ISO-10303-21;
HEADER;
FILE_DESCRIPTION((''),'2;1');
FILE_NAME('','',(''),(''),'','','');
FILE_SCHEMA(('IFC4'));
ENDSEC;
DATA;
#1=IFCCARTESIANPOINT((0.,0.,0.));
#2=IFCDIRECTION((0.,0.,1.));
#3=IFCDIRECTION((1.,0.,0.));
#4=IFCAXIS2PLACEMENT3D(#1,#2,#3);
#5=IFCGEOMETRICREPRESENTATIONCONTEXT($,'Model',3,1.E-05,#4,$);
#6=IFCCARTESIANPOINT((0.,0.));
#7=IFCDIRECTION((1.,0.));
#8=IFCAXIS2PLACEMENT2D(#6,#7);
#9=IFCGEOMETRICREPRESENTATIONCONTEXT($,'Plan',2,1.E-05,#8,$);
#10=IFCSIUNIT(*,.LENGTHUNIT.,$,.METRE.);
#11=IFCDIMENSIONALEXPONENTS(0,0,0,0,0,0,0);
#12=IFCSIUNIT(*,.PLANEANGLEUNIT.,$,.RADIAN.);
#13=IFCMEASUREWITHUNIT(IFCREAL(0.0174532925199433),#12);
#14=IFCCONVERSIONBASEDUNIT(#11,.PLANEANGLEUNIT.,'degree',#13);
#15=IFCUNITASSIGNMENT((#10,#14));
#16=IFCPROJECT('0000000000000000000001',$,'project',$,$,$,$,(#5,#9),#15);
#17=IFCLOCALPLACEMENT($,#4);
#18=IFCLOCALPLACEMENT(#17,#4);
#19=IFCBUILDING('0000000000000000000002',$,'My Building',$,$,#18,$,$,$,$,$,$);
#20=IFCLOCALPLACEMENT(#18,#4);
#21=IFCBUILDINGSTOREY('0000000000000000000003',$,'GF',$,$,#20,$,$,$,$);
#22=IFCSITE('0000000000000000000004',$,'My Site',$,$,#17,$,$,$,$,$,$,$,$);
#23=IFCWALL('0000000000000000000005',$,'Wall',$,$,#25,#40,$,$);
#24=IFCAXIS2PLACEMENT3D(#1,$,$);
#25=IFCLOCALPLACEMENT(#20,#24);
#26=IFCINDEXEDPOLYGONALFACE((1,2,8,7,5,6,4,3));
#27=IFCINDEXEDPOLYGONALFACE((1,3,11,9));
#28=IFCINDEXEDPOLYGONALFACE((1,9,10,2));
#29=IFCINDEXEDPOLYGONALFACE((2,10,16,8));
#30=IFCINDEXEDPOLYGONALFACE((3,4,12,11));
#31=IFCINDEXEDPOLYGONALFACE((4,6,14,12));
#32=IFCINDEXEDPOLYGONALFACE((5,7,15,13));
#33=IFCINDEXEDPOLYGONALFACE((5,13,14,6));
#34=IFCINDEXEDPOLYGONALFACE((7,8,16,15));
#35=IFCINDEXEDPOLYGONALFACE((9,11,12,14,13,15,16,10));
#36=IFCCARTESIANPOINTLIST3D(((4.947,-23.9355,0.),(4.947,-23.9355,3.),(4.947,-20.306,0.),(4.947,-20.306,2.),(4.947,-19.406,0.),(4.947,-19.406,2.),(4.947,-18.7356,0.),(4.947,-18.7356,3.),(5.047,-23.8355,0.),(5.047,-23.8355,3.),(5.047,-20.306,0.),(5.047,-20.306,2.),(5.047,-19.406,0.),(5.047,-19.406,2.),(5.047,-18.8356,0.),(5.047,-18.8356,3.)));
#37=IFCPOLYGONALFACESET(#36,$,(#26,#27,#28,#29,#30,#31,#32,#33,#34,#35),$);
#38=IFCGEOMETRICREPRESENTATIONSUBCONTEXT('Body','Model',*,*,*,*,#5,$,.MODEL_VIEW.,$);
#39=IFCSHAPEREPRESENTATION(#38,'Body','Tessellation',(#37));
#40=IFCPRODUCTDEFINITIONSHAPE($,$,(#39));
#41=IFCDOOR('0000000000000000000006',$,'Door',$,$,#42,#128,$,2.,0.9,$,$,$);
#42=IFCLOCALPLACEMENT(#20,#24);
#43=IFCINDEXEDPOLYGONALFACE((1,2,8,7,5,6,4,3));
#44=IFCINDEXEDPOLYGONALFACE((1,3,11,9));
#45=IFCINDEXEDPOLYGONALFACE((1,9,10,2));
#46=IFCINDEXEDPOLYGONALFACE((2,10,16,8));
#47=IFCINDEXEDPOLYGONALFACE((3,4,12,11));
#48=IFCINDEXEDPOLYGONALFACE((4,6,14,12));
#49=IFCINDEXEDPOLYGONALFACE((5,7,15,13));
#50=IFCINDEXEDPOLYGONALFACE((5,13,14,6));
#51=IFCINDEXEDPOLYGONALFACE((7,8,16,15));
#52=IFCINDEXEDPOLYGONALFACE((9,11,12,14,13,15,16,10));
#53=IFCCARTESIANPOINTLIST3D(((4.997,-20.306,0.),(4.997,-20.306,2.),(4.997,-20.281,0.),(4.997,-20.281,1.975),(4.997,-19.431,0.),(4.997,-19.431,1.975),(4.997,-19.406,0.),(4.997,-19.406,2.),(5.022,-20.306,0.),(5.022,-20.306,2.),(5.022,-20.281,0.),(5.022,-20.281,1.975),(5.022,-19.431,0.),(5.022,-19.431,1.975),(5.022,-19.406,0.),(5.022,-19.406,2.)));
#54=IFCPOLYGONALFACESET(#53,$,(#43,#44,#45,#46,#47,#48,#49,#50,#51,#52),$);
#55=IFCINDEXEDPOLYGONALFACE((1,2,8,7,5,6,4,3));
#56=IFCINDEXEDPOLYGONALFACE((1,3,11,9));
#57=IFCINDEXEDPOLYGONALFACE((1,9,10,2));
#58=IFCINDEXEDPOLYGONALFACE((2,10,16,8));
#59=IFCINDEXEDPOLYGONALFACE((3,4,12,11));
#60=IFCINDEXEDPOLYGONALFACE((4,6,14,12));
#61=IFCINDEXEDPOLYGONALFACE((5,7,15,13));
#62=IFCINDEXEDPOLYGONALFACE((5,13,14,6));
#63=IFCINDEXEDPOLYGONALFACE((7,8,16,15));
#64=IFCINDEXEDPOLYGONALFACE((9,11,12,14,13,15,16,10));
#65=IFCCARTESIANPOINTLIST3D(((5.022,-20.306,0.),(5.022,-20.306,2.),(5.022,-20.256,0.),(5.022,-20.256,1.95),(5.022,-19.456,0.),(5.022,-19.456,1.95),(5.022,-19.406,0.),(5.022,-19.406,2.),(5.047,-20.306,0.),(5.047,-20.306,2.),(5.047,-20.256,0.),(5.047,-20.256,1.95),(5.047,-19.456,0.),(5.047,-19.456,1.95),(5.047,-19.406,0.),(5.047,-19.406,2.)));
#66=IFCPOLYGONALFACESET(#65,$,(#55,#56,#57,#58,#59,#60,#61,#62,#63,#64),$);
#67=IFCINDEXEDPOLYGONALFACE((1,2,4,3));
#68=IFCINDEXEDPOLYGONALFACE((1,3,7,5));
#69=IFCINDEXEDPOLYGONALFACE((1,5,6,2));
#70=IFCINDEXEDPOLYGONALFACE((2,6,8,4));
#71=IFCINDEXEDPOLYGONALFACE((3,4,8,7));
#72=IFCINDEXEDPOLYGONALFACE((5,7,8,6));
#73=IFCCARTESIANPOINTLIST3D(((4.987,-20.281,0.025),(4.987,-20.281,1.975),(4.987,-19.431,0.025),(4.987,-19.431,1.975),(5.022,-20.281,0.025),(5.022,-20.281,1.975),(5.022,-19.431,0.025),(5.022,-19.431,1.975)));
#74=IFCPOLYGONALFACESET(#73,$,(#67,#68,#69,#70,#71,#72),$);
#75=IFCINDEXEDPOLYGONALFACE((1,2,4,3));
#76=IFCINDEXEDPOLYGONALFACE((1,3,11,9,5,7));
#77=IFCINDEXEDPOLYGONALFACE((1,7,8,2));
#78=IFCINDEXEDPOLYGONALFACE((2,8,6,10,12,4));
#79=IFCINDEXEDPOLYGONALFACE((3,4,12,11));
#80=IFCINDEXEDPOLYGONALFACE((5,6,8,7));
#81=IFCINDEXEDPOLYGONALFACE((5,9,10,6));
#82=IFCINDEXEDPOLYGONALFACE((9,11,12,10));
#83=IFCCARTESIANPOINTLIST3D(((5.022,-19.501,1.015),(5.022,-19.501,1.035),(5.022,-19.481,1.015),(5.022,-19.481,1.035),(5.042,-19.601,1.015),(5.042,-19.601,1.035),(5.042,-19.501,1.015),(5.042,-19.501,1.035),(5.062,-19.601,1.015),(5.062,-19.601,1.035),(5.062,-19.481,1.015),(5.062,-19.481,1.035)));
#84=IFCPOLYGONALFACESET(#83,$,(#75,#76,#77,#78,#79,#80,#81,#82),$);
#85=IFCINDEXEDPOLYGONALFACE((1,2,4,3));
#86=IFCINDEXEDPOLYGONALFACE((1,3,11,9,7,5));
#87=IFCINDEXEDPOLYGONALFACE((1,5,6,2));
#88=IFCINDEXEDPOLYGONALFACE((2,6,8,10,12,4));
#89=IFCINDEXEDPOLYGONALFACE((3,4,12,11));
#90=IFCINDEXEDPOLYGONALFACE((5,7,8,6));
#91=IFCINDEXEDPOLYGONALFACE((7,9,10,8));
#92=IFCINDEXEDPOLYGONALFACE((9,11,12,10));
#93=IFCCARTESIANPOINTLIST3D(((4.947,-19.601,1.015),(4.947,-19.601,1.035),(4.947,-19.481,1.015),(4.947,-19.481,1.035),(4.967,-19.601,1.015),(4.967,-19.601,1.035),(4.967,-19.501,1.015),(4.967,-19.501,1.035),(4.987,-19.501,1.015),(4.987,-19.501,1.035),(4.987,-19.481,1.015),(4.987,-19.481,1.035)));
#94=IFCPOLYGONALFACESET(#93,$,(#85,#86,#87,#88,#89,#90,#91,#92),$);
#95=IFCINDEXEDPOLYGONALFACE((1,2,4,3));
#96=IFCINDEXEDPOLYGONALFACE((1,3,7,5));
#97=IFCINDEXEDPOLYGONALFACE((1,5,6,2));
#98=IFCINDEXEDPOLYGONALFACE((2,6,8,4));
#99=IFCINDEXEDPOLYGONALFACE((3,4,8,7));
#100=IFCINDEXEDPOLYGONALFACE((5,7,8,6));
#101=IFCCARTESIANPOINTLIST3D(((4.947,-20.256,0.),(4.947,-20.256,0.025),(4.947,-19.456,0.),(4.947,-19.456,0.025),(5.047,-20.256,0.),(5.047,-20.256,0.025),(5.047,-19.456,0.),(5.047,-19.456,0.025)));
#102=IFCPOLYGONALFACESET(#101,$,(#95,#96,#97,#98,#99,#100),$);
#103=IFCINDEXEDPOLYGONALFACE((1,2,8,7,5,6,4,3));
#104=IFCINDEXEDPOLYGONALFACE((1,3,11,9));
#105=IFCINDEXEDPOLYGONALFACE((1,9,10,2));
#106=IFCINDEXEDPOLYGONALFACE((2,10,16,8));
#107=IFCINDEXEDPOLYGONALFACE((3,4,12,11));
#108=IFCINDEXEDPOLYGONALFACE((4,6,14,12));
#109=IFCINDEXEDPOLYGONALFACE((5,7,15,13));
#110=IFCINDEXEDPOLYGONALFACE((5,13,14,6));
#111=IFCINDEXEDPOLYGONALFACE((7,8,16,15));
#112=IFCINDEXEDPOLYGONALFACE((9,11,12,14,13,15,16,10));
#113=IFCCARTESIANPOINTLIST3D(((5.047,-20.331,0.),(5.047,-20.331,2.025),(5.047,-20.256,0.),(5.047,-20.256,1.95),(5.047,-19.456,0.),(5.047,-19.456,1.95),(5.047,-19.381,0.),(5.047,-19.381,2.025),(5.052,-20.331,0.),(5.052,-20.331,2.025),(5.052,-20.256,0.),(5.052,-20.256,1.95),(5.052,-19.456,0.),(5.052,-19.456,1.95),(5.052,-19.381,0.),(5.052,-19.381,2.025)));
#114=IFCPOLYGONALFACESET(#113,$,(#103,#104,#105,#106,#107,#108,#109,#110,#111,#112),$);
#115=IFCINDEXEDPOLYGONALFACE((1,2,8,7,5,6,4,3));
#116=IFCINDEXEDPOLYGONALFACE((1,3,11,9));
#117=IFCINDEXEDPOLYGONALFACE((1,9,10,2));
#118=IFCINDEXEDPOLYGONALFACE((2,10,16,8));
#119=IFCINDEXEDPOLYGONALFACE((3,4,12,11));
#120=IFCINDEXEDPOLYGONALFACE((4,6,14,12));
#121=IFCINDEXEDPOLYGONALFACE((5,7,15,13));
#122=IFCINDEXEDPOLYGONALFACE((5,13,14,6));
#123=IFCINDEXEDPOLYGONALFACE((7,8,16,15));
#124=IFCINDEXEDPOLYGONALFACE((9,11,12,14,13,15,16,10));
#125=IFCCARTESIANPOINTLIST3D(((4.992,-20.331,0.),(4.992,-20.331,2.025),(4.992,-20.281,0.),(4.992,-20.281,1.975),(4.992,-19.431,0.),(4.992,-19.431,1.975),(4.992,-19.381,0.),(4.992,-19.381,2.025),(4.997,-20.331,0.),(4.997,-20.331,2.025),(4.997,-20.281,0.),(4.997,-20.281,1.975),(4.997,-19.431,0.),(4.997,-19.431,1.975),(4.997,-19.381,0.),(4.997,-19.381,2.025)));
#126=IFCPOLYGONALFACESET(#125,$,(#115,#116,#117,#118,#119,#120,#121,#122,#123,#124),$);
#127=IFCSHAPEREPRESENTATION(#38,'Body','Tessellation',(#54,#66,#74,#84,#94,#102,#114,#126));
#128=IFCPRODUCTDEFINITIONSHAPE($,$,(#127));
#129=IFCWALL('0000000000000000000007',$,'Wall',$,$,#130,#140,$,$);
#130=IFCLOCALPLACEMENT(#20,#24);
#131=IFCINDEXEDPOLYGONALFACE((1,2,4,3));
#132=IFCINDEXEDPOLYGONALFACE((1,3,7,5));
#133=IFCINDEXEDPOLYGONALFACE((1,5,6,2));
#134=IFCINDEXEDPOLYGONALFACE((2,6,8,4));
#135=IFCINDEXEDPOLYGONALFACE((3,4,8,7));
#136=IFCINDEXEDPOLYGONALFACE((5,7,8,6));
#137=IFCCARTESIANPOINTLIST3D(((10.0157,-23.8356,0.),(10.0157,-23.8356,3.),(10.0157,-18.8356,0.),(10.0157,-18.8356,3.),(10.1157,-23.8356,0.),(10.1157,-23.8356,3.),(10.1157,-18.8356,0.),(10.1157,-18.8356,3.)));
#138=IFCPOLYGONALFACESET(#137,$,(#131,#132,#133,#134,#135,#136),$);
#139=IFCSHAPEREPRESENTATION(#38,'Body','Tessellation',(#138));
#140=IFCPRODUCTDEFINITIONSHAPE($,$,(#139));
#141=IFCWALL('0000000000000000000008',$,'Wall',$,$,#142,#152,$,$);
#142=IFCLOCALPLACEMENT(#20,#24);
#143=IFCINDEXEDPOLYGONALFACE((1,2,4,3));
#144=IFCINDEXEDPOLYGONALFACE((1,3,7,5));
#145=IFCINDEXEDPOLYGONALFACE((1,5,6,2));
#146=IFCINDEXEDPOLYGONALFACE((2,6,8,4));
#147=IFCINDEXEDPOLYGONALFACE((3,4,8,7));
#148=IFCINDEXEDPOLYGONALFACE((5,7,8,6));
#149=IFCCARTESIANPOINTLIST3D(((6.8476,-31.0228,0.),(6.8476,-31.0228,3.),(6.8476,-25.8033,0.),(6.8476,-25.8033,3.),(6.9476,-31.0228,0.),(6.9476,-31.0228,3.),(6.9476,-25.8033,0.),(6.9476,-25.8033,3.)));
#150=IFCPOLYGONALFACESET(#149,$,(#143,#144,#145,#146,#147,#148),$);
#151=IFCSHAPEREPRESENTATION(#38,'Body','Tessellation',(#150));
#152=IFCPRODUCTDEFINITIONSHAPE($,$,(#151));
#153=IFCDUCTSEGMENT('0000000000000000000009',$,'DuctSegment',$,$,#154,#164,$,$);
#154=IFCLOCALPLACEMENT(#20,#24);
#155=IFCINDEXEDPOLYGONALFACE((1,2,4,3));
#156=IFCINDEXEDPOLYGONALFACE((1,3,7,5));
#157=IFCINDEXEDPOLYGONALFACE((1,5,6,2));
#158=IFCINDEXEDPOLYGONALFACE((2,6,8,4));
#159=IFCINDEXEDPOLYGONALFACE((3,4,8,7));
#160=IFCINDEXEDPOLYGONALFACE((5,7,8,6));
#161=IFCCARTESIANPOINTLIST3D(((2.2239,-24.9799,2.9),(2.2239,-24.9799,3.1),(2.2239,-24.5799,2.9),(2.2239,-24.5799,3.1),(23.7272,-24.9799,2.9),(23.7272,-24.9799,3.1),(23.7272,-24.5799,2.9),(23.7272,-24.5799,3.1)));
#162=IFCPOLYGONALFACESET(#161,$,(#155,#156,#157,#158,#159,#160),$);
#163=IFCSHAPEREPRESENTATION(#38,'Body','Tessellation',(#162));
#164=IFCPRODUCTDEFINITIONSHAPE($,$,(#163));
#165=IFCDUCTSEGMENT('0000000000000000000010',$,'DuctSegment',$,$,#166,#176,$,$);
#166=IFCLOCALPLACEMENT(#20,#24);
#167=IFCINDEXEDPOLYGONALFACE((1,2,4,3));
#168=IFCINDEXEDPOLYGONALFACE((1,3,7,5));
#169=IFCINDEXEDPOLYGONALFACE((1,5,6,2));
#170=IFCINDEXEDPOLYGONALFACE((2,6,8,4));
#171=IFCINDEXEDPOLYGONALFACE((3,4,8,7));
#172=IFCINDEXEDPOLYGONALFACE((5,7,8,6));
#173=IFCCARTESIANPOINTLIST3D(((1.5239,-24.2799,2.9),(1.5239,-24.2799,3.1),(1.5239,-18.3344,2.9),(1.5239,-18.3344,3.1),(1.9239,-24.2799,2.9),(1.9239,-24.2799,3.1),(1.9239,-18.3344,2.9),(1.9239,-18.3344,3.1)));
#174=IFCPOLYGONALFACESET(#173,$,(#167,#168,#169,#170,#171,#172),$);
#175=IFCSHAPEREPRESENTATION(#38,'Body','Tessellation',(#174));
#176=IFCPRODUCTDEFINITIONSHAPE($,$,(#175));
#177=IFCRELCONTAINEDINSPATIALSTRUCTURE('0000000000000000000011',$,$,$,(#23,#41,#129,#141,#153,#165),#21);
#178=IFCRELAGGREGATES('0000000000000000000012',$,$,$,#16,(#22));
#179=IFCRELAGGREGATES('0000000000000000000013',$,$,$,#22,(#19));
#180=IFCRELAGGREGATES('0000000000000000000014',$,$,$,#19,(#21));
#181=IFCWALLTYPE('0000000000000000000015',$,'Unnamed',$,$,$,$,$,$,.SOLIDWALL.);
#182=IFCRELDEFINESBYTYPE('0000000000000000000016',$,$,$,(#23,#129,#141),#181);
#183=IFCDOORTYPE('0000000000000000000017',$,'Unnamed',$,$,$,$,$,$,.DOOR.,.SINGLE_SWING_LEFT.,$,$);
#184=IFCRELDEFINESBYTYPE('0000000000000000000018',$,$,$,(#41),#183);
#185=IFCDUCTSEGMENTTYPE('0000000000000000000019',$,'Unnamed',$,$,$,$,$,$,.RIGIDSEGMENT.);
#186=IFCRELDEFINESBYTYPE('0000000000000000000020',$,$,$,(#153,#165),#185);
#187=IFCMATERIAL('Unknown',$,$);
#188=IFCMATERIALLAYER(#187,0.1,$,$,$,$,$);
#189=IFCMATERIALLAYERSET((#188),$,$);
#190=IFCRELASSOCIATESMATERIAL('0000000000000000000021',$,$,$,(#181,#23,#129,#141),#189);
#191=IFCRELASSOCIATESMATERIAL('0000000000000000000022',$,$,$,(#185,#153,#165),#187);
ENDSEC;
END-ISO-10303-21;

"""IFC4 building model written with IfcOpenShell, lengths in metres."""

from ifc_helpers import new_model, entity, si_unit, converted_unit, frame, origin_with_axes, origin_2d_with_axis, place, context, subcontext, project, spatial, line, indexed_curve, rectangle, outline, extrude, shape, source, transform, mapped, material, layer, layer_set, layer_usage, material_profile, profile_set, profile_usage, type_object, type_shapes, element, fill, save


model = new_model("IFC4")

# Units and contexts
model_context = context("Model", 3, precision=1e-05, world=origin_with_axes())
plan_context = context("Plan", 2, precision=1e-05, world=origin_2d_with_axis())
body_context_1 = subcontext(model_context, "Body", "Model", "MODEL_VIEW")
body_context_2 = subcontext(plan_context, "Body", "Plan", "PLAN_VIEW")
ifc_project = project(units=[si_unit("LENGTHUNIT", "METRE"), converted_unit("PLANEANGLEUNIT", "degree", entity("IfcReal", 0.0174532925199433), si_unit("PLANEANGLEUNIT", "RADIAN"), dimensions=[0, 0, 0, 0, 0, 0, 0])], contexts=[model_context, plan_context])

# Site, building, storey
site_placement = place(None, origin_with_axes())
site = spatial("IfcSite", under=ifc_project, at=site_placement, Name="My Site")
building_placement = place(site_placement, origin_with_axes())
building = spatial("IfcBuilding", under=site, at=building_placement, Name="My Building")
storey_placement = place(building_placement, origin_with_axes())
storey = spatial("IfcBuildingStorey", under=building, at=storey_placement, Name="GF")

# Shared definitions
ifc_material = material(Name="Unknown")
ifc_layer = layer(ifc_material, 0.1)
ifc_layer_set = layer_set([ifc_layer])
wall_type = type_object("IfcWallType", Name="Unnamed", PredefinedType="SOLIDWALL", material=ifc_layer_set)

# Shared definitions
shared_shape_1 = source(origin_with_axes(), body_context_1, "Body", "SweptSolid", [
    extrude(outline(indexed_curve([(0.0, 0.0), (0.9, 0.0), (0.9, 2.0), (0.0, 2.0)], segments=[line(1, 2, 3, 4, 1)])), frame((0.0, -0.6, 0.0), z_axis=(0.0, -1.0, 0.0), x_axis=(1.0, 0.0, 0.0)), (0.0, 0.0, -1.0), 1.2),
])
door_type = type_object("IfcDoorType", Name="Unnamed", OperationType="SINGLE_SWING_LEFT", PredefinedType="DOOR")
shared_shape_2 = source(origin_with_axes(), body_context_1, "Body", "SweptSolid", [
    extrude(outline(indexed_curve([(0.0, 0.0), (0.0, 2.0), (0.9, 2.0), (0.9, 0.0), (0.875, 0.0), (0.875, 1.975), (0.025, 1.975), (0.025, 0.0)], segments=[line(1, 2, 3, 4, 5, 6, 7, 8, 1)])), frame((0.0, 0.025, 0.0), z_axis=(0.0, -1.0, 0.0), x_axis=(1.0, 0.0, 0.0)), (0.0, 0.0, -1.0), 0.025),
    extrude(outline(indexed_curve([(0.0, 0.0), (0.0, 2.0), (0.9, 2.0), (0.9, 0.0), (0.85, 0.0), (0.85, 1.95), (0.05, 1.95), (0.05, 0.0)], segments=[line(1, 2, 3, 4, 5, 6, 7, 8, 1)])), frame((0.0, 0.0, 0.0), z_axis=(0.0, -1.0, 0.0), x_axis=(1.0, 0.0, 0.0)), (0.0, 0.0, -1.0), 0.025),
    extrude(outline(indexed_curve([(0.0, 0.0), (0.85, 0.0), (0.85, 0.035), (0.0, 0.035)], segments=[line(1, 2, 3, 4, 1)])), frame((0.025, 0.025, 0.025), z_axis=(0.0, 0.0, 1.0), x_axis=(1.0, 0.0, 0.0)), (0.0, 0.0, 1.0), 1.95),
    extrude(outline(indexed_curve([(0.0, 0.0), (0.0, -0.04), (-0.12, -0.04), (-0.12, -0.02), (-0.02, -0.02), (-0.02, 0.0)], segments=[line(1, 2, 3, 4, 5, 6, 1)])), frame((0.825, 0.025, 1.015), z_axis=(0.0, 0.0, 1.0), x_axis=(1.0, 0.0, 0.0)), (0.0, 0.0, 1.0), 0.02),
    extrude(outline(indexed_curve([(0.0, 0.0), (0.0, 0.04), (-0.12, 0.04), (-0.12, 0.02), (-0.02, 0.02), (-0.02, 0.0)], segments=[line(1, 2, 3, 4, 5, 6, 1)])), frame((0.825, 0.06, 1.015), z_axis=(0.0, 0.0, 1.0), x_axis=(1.0, 0.0, 0.0)), (0.0, 0.0, 1.0), 0.02),
    extrude(outline(indexed_curve([(0.0, 0.0), (0.8, 0.0), (0.8, 0.1), (0.0, 0.1)], segments=[line(1, 2, 3, 4, 1)])), frame((0.05, 0.0, 0.0), z_axis=(0.0, 0.0, 1.0), x_axis=(1.0, 0.0, 0.0)), (0.0, 0.0, 1.0), 0.025),
    extrude(outline(indexed_curve([(0.0, 0.0), (0.0, 2.025), (0.95, 2.025), (0.95, 0.0), (0.875, 0.0), (0.875, 1.95), (0.075, 1.95), (0.075, 0.0)], segments=[line(1, 2, 3, 4, 5, 6, 7, 8, 1)])), frame((-0.025, -0.005, 0.0), z_axis=(0.0, -1.0, 0.0), x_axis=(1.0, 0.0, 0.0)), (0.0, 0.0, -1.0), 0.005),
    extrude(outline(indexed_curve([(0.0, 0.0), (0.0, 2.025), (0.95, 2.025), (0.95, 0.0), (0.9, 0.0), (0.9, 1.975), (0.05, 1.975), (0.05, 0.0)], segments=[line(1, 2, 3, 4, 5, 6, 7, 8, 1)])), frame((-0.025, 0.05, 0.0), z_axis=(0.0, -1.0, 0.0), x_axis=(1.0, 0.0, 0.0)), (0.0, 0.0, -1.0), 0.005),
])
shared_shape_3 = source(origin_with_axes(), body_context_2, "Body", "Curve2D", [
    entity("IfcIndexedPolyCurve", entity("IfcCartesianPointList2D", [[0.0, 0.0], [0.0, 0.05], [0.025, 0.05], [0.025, 0.025], [0.05, 0.025], [0.05, 0.0]]), [entity("IfcLineIndex", [1, 2, 3, 4, 5, 6, 1])]),
    entity("IfcIndexedPolyCurve", entity("IfcCartesianPointList2D", [[0.9, 0.0], [0.9, 0.05], [0.875, 0.05], [0.875, 0.025], [0.85, 0.025], [0.85, 0.0]]), [entity("IfcLineIndex", [1, 2, 3, 4, 5, 6, 1])]),
    entity("IfcTrimmedCurve", entity("IfcEllipse", entity("IfcAxis2Placement2D", entity("IfcCartesianPoint", [0.06, 0.05]), entity("IfcDirection", [1.0, 0.0])), 0.815, 0.85), [entity("IfcCartesianPoint", [0.875, 0.05])], [entity("IfcCartesianPoint", [0.06, 0.9])], True, "CARTESIAN"),
    entity("IfcIndexedPolyCurve", entity("IfcCartesianPointList2D", [[0.025, 0.05], [0.06, 0.05], [0.06, 0.9], [0.025, 0.9]]), [entity("IfcLineIndex", [1, 2, 3, 4, 1])]),
])
type_shapes(door_type, [shared_shape_2, shared_shape_3])

# Wall, opening, door
ifc_layer_usage_1 = layer_usage(ifc_layer_set, "AXIS2", "POSITIVE", 0.0)
wall_1_placement = place(storey_placement, frame((5.047, -23.8355, 0.0), z_axis=(0.0, 0.0, 1.0), x_axis=(0.0, 1.0, 0.0)))
wall_1 = element("IfcWall", 1, at=wall_1_placement, inside=storey, type_object=wall_type, material=ifc_layer_usage_1, Name="Wall", context=body_context_1, shape_type="SweptSolid", body=[
    extrude(outline(indexed_curve([(0.0, 0.0), (-0.1, 0.1), (5.1, 0.1), (5.0, 0.0)], segments=[line(1, 2, 3, 4, 1)])), origin_with_axes(), (0.0, 0.0, 1.0), 3.0),
])
opening_1_placement = place(wall_1_placement, frame((3.5295, 0.0, 0.0), z_axis=(0.0, 0.0, 1.0), x_axis=(1.0, 0.0, 0.0)))
opening_1 = element("IfcOpeningElement", 2, at=opening_1_placement, cuts=wall_1, PredefinedType="OPENING", context=body_context_1, shape_type="MappedRepresentation", body=[
    mapped(shared_shape_1, transform((0.0, 0.0, 0.0), x_axis=(1.0, 0.0, 0.0), y_axis=(0.0, 1.0, 0.0), z_axis=(0.0, 0.0, 1.0), scale=1.0)),
])
door_1_placement = place(opening_1_placement, frame((0.0, 0.0, 0.0), z_axis=(0.0, 0.0, 1.0), x_axis=(1.0, 0.0, 0.0)))
door_1 = element("IfcDoor", 3, at=door_1_placement, inside=storey, type_object=door_type, Name="Door", OverallHeight=2.0, OverallWidth=0.9, shapes=[
    shape(body_context_1, "Body", "MappedRepresentation", [mapped(shared_shape_2, transform((0.0, 0.0, 0.0), x_axis=(1.0, 0.0, 0.0), y_axis=(0.0, 1.0, 0.0), z_axis=(0.0, 0.0, 1.0), scale=1.0))]),
    shape(body_context_2, "Body", "MappedRepresentation", [mapped(shared_shape_3, transform((0.0, 0.0, 0.0), x_axis=(1.0, 0.0, 0.0), y_axis=(0.0, 1.0, 0.0), z_axis=(0.0, 0.0, 1.0), scale=1.0))]),
])
fill(opening_1, door_1)

# Walls
ifc_layer_usage_2 = layer_usage(ifc_layer_set, "AXIS2", "POSITIVE", 0.0)
wall_2_placement = place(storey_placement, frame((10.0157, -18.8356, 0.0), z_axis=(0.0, 0.0, 1.0), x_axis=(0.0, -1.0, 0.0)))
element("IfcWall", 4, at=wall_2_placement, inside=storey, type_object=wall_type, material=ifc_layer_usage_2, Name="Wall", context=body_context_1, shape_type="SweptSolid", body=[
    extrude(outline(indexed_curve([(0.0, 0.0), (0.0, 0.1), (5.0, 0.1), (5.0, 0.0)], segments=[line(1, 2, 3, 4, 1)])), origin_with_axes(), (0.0, 0.0, 1.0), 3.0),
])
ifc_layer_usage_3 = layer_usage(ifc_layer_set, "AXIS2", "POSITIVE", 0.0)
wall_3_placement = place(storey_placement, frame((6.8476, -25.8033, 0.0), z_axis=(0.0, 0.0, 1.0), x_axis=(0.0, -1.0, 0.0)))
element("IfcWall", 5, at=wall_3_placement, inside=storey, type_object=wall_type, material=ifc_layer_usage_3, Name="Wall", context=body_context_1, shape_type="SweptSolid", body=[
    extrude(outline(indexed_curve([(0.0, 0.0), (0.0, 0.1), (5.2195, 0.1), (5.2195, 0.0)], segments=[line(1, 2, 3, 4, 1)])), origin_with_axes(), (0.0, 0.0, 1.0), 3.0),
])

# Duct segments
ifc_material_profile_1 = material_profile(ifc_material, rectangle(XDim=0.4, YDim=0.2))
ifc_profile_set_1 = profile_set([ifc_material_profile_1])
ifc_profile_usage_1 = profile_usage(ifc_profile_set_1, cardinal=5)
duct_segment_type = type_object("IfcDuctSegmentType", Name="Unnamed", PredefinedType="RIGIDSEGMENT", material=ifc_profile_set_1)
duct_segment_1_placement = place(storey_placement, frame((2.2239, -24.7799, 3.0), z_axis=(1.0, -0.000001, 0.000001), x_axis=(0.000001, 1.0, 0.0)))
element("IfcDuctSegment", 6, at=duct_segment_1_placement, inside=storey, type_object=duct_segment_type, material=ifc_profile_usage_1, Name="DuctSegment", context=body_context_1, shape_type="SweptSolid", body=[
    extrude(rectangle(XDim=0.4, YDim=0.2), origin_with_axes(), (0.0, 0.0, 1.0), 21.5032),
])
ifc_profile_usage_2 = profile_usage(ifc_profile_set_1, cardinal=5)
duct_segment_2_placement = place(storey_placement, frame((1.7239, -18.3344, 3.0), z_axis=(0.0, -1.0, 0.0), x_axis=(1.0, 0.0, 0.0)))
element("IfcDuctSegment", 7, at=duct_segment_2_placement, inside=storey, type_object=duct_segment_type, material=ifc_profile_usage_2, Name="DuctSegment", context=body_context_1, shape_type="SweptSolid", body=[
    extrude(rectangle(XDim=0.4, YDim=0.2), origin_with_axes(), (0.0, 0.0, 1.0), 5.9455),
])

save(model, "model.ifc")
